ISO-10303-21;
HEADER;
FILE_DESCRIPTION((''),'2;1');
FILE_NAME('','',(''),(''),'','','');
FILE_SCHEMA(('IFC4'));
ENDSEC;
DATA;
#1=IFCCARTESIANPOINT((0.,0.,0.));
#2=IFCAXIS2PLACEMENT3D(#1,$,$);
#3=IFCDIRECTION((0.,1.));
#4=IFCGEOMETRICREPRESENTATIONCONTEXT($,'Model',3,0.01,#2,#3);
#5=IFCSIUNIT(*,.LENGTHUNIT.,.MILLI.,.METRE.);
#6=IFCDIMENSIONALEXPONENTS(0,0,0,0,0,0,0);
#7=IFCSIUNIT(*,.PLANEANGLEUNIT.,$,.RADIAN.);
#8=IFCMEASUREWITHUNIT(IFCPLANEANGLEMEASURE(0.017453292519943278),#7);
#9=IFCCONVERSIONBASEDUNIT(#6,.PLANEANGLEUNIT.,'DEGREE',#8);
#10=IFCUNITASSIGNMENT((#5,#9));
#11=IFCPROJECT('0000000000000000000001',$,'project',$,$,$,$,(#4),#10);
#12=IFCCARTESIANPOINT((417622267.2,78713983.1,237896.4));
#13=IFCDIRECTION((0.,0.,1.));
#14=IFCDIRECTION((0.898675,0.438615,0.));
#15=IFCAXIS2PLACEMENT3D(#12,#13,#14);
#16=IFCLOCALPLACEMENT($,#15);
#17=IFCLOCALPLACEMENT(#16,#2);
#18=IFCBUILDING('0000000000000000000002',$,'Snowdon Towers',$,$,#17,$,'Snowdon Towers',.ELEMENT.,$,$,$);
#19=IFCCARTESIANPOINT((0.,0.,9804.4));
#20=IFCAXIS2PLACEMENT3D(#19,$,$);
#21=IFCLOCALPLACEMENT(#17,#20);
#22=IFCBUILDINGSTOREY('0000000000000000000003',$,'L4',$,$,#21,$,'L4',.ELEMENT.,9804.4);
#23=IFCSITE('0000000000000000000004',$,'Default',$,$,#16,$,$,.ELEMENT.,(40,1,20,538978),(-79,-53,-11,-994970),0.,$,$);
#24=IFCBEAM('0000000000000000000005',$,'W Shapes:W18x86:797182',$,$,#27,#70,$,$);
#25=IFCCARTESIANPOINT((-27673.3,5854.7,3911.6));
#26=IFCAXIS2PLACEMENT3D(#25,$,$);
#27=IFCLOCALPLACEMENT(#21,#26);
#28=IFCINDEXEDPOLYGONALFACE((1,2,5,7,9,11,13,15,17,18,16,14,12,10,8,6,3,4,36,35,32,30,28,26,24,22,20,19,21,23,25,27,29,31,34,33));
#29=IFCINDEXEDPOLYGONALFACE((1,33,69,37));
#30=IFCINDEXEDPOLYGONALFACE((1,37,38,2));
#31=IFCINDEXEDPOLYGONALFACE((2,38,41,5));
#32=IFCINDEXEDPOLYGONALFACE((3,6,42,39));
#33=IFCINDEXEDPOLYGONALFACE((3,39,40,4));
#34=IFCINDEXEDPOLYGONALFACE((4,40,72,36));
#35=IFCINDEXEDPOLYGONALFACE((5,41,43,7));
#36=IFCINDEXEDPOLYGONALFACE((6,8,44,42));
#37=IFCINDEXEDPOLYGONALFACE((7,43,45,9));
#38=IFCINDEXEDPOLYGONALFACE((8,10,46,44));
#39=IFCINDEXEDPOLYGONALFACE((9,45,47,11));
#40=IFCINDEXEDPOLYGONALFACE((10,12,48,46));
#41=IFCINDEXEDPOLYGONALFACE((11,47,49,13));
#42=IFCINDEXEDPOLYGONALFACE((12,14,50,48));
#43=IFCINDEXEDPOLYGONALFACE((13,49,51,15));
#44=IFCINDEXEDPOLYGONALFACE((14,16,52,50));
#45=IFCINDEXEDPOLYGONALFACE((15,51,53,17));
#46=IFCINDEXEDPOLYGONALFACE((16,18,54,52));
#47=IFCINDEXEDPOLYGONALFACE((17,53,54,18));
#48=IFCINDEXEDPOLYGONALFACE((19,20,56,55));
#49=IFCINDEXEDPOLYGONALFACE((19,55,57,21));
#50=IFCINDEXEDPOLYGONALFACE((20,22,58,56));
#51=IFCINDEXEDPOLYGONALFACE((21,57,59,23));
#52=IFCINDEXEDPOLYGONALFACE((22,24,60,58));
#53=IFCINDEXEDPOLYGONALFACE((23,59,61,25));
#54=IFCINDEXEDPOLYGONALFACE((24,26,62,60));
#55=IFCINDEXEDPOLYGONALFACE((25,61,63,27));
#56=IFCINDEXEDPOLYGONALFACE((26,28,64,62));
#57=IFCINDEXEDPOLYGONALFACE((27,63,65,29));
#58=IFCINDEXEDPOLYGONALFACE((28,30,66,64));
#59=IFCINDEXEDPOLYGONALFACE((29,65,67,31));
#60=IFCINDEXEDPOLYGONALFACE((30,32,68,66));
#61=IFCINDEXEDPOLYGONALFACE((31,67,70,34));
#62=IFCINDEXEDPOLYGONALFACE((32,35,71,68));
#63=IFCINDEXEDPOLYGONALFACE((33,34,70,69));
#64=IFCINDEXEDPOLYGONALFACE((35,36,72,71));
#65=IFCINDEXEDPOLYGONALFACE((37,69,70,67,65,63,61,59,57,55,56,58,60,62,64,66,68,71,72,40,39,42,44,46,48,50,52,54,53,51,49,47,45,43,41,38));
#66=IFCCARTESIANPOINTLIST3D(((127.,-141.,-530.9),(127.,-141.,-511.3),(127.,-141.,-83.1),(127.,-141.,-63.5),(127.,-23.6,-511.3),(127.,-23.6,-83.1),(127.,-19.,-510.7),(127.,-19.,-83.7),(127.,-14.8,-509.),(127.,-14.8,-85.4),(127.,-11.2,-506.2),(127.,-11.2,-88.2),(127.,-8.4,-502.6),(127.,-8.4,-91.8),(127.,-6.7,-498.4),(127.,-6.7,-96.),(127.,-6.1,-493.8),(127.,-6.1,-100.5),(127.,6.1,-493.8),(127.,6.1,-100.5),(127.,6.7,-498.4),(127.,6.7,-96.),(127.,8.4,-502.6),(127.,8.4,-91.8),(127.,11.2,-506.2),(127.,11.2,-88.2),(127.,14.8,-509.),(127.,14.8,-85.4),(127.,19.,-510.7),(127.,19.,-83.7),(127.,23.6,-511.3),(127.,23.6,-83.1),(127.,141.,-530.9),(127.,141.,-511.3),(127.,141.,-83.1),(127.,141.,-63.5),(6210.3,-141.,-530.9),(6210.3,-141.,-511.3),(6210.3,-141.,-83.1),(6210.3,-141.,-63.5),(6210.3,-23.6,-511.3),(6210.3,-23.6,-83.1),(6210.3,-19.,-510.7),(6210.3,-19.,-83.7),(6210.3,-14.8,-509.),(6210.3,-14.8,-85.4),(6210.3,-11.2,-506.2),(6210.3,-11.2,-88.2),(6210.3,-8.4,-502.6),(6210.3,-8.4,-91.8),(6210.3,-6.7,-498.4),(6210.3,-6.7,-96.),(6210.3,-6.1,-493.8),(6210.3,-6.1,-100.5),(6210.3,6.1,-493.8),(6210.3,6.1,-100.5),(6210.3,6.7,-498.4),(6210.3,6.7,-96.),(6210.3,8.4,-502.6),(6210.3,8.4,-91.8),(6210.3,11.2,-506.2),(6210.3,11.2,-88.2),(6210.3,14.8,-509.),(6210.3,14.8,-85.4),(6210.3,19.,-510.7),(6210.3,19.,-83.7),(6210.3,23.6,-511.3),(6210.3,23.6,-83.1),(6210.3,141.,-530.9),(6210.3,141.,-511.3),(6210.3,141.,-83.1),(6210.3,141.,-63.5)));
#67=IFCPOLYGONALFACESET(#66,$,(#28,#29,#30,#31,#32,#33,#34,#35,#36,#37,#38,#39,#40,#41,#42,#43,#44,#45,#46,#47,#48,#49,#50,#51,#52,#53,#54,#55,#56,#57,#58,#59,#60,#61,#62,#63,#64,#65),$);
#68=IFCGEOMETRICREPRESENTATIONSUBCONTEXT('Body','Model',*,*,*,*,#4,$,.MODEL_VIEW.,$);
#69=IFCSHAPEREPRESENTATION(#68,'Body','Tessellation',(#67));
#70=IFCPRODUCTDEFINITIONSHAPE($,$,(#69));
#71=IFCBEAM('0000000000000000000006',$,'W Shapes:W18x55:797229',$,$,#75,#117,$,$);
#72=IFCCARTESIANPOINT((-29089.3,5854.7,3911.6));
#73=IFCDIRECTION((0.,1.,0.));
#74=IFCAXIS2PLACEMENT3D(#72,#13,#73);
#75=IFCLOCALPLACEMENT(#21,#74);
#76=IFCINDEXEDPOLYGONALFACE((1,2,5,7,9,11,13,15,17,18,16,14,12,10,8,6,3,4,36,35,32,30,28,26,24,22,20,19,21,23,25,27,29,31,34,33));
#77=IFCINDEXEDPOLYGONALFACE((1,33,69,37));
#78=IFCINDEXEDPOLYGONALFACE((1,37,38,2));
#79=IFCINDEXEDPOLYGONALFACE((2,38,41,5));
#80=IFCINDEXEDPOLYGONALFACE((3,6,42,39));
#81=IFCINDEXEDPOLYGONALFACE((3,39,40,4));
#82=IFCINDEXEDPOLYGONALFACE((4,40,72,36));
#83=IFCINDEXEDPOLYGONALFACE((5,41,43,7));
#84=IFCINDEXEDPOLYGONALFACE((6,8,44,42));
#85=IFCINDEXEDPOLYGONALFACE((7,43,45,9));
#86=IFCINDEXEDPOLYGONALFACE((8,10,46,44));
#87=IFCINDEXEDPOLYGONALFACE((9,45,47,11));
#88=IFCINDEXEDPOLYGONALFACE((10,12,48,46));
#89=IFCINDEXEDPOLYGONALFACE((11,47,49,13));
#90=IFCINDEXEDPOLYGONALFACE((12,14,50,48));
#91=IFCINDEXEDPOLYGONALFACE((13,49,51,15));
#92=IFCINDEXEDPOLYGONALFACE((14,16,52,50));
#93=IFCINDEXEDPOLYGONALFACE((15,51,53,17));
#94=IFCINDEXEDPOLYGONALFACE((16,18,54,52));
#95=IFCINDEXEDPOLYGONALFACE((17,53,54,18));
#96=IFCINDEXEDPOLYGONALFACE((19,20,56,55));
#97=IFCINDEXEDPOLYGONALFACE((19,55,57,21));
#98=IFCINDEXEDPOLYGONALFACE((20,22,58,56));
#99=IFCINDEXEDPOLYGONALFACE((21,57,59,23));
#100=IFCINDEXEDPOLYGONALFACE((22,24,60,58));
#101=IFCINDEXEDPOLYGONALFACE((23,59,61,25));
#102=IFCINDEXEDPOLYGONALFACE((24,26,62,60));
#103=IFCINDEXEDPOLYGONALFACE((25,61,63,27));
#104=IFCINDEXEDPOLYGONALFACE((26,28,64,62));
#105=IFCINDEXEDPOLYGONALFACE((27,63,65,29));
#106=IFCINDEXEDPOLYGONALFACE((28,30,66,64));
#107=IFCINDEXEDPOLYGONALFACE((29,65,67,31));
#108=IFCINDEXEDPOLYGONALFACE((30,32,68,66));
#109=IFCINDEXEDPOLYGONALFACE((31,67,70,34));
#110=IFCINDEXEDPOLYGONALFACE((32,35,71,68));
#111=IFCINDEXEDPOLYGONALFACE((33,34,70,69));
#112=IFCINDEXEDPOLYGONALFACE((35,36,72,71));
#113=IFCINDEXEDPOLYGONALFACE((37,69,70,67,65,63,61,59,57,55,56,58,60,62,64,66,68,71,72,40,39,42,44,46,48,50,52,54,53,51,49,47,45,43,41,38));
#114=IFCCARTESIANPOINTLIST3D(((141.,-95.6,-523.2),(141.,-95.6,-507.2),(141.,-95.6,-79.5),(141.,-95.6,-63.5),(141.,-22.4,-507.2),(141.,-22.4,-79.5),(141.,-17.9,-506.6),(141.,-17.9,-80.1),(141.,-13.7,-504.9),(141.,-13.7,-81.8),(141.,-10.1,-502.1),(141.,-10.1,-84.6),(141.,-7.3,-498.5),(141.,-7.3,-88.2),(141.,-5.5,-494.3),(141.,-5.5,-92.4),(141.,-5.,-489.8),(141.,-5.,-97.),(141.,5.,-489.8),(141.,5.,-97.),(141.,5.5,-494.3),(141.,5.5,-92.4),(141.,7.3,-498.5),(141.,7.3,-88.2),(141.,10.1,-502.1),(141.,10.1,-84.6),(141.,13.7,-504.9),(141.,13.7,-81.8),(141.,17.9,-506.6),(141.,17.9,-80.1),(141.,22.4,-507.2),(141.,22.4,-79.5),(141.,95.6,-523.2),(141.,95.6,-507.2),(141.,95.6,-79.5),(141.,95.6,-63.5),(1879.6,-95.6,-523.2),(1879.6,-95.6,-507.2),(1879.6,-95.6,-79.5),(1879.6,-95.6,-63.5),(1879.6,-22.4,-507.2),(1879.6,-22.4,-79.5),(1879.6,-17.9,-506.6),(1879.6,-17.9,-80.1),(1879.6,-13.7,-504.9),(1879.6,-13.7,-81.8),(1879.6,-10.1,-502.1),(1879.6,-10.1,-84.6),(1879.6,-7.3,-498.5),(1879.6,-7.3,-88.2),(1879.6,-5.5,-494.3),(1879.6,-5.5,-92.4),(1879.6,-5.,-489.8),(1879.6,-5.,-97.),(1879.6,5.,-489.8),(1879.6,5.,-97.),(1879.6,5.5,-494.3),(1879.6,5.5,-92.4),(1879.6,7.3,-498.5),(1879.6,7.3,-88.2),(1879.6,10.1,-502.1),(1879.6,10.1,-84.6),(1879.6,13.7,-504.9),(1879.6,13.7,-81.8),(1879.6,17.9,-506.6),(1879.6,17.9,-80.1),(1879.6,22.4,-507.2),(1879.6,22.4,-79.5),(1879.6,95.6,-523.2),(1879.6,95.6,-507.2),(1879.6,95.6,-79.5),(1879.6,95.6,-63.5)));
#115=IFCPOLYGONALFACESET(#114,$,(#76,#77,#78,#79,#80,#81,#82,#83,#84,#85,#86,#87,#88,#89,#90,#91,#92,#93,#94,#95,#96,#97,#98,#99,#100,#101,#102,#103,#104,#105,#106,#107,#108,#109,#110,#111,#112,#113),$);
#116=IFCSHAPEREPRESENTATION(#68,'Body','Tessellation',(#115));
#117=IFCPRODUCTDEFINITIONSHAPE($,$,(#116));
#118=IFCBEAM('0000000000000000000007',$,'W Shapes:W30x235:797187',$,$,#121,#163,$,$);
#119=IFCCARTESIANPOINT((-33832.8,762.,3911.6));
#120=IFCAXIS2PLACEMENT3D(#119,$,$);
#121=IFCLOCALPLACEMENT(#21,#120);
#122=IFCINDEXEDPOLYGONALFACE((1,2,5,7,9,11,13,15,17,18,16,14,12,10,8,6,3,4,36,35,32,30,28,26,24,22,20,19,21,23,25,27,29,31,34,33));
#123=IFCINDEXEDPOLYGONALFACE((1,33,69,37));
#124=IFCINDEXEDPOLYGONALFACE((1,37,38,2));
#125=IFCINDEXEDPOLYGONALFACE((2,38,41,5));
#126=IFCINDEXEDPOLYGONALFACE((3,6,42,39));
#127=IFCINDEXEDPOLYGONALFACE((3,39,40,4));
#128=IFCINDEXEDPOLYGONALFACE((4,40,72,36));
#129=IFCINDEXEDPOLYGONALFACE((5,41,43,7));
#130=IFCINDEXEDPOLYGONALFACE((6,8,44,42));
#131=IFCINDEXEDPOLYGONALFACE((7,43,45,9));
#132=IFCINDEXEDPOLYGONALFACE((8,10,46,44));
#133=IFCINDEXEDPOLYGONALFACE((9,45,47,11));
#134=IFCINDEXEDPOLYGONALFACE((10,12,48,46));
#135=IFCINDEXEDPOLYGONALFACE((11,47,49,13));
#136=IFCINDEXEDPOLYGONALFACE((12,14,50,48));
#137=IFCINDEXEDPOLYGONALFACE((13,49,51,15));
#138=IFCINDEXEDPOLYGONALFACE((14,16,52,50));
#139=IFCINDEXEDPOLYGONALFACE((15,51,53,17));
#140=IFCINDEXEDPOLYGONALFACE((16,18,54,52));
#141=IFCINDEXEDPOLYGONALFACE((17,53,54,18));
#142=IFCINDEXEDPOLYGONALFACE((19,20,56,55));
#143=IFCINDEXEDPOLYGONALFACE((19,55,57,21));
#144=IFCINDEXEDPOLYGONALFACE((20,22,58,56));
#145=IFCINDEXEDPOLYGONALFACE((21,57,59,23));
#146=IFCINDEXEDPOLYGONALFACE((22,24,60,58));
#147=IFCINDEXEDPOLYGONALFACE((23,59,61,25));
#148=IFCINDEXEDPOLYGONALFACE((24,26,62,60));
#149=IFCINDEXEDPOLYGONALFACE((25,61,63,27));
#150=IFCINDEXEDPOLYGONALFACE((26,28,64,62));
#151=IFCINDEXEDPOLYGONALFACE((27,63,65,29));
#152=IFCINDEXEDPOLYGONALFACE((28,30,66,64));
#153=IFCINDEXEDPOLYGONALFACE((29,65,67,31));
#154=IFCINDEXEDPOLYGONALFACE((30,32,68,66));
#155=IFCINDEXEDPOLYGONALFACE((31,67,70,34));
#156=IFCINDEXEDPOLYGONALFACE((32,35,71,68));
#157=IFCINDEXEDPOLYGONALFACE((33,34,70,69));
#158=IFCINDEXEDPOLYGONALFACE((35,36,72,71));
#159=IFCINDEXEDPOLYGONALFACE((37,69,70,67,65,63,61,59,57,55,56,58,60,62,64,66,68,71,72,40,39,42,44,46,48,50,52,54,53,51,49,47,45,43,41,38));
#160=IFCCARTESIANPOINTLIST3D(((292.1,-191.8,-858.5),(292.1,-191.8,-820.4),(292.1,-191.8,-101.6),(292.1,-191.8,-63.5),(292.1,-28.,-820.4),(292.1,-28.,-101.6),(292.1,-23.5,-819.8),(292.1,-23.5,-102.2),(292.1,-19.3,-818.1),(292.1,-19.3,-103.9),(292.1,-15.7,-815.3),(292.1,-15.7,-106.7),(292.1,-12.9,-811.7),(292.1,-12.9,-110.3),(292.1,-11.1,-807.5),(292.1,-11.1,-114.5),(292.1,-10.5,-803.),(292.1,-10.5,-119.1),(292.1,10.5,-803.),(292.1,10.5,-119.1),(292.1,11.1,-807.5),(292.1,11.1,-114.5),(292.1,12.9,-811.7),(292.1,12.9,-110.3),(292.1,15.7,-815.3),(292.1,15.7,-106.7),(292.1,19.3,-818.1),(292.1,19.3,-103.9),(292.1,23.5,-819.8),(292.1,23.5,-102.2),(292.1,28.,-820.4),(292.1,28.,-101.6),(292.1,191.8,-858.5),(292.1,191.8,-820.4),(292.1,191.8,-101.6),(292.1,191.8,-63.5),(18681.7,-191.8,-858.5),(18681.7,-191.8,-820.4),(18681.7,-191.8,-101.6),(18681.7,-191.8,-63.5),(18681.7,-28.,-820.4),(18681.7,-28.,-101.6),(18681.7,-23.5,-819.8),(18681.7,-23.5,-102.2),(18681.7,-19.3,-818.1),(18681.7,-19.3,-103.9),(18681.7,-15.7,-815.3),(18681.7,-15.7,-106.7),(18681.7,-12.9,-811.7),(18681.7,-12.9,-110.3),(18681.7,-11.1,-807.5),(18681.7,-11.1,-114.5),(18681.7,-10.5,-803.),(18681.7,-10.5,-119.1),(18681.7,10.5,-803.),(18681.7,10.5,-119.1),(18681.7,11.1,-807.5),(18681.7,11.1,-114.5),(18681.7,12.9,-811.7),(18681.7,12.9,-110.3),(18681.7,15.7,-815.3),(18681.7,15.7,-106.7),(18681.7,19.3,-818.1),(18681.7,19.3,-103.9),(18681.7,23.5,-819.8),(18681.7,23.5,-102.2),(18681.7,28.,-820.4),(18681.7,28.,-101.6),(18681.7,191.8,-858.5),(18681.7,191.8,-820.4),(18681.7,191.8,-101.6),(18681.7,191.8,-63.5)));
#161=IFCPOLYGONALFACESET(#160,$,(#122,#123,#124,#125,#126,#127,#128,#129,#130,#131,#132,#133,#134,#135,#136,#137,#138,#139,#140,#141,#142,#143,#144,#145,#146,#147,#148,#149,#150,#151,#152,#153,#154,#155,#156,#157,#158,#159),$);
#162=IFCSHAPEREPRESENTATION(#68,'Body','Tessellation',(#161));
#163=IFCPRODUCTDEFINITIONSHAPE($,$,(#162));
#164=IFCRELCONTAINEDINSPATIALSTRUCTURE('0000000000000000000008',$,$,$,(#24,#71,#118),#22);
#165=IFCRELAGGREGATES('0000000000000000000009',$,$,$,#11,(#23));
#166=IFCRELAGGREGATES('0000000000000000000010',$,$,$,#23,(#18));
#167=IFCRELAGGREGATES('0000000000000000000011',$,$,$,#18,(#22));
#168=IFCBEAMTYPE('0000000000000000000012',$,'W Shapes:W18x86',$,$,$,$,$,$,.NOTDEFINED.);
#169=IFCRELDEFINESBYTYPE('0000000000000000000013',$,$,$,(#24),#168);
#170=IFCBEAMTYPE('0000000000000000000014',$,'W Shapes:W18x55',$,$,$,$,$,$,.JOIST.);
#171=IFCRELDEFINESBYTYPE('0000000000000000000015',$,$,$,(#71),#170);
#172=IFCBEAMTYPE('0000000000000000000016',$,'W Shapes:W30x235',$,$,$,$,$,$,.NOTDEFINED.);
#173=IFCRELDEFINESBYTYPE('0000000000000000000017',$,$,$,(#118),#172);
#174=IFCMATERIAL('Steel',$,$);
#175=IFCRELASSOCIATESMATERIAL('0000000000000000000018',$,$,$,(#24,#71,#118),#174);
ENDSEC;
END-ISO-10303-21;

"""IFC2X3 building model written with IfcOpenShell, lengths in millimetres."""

from ifc_helpers import new_model, entity, si_unit, converted_unit, direction, frame, frame_2d, origin, place, context, subcontext, project, spatial, i_section, extrude, material, type_object, element, save


model = new_model("IFC2X3")

# Units and contexts
model_context = context("Model", 3, precision=0.01, world=origin(), true_north=direction((0.0, 1.0)))
body_context = subcontext(model_context, "Body", "Model", "MODEL_VIEW")
ifc_project = project(units=[si_unit("LENGTHUNIT", "METRE", prefix="MILLI"), converted_unit("PLANEANGLEUNIT", "DEGREE", entity("IfcPlaneAngleMeasure", 0.017453292519943278), si_unit("PLANEANGLEUNIT", "RADIAN"), dimensions=[0, 0, 0, 0, 0, 0, 0])], contexts=[model_context])

# Site, building, storey
site_placement = place(None, frame((417622267.2, 78713983.1, 237896.4), z_axis=(0.0, 0.0, 1.0), x_axis=(0.898675, 0.438615, 0.0)))
site = spatial("IfcSite", under=ifc_project, at=site_placement, Name="Default", CompositionType="ELEMENT", RefLatitude=(40, 1, 20, 538978), RefLongitude=(-79, -53, -11, -994970), RefElevation=0.0)
building_placement = place(site_placement, origin())
building = spatial("IfcBuilding", under=site, at=building_placement, Name="Snowdon Towers", LongName="Snowdon Towers", CompositionType="ELEMENT")
storey_placement = place(building_placement, frame((0.0, 0.0, 9804.4)))
storey = spatial("IfcBuildingStorey", under=building, at=storey_placement, Name="L4", LongName="L4", CompositionType="ELEMENT", Elevation=9804.4)

# Shared definitions
ifc_material_1 = material(Name="Steel")

# Beams
beam_type_1 = type_object("IfcBeamType", Name="W Shapes:W18x86", PredefinedType="NOTDEFINED")
beam_1_placement = place(storey_placement, frame((-27673.3, 5854.7, 3911.6)))
element("IfcBeam", 1, at=beam_1_placement, inside=storey, type_object=beam_type_1, material=ifc_material_1, Name="W Shapes:W18x86:797182", context=body_context, shape_type="SweptSolid", body=[
    extrude(i_section(OverallWidth=281.9, OverallDepth=467.4, WebThickness=12.2, FlangeThickness=19.6, FilletRadius=17.5, at=frame_2d((0.0, 0.0), x_axis=(0.0, 1.0))), frame((127.0, 0.0, -297.2), z_axis=(1.0, 0.0, 0.0), x_axis=(0.0, 0.0, -1.0)), (0.0, 0.0, 1.0), 6083.3),
])
beam_type_2 = type_object("IfcBeamType", Name="W Shapes:W18x55", PredefinedType="JOIST")
beam_2_placement = place(storey_placement, frame((-29089.3, 5854.7, 3911.6), z_axis=(0.0, 0.0, 1.0), x_axis=(0.0, 1.0, 0.0)))
element("IfcBeam", 2, at=beam_2_placement, inside=storey, type_object=beam_type_2, material=ifc_material_1, Name="W Shapes:W18x55:797229", context=body_context, shape_type="SweptSolid", body=[
    extrude(i_section(OverallWidth=191.3, OverallDepth=459.7, WebThickness=9.9, FlangeThickness=16.0, FilletRadius=17.5, at=frame_2d((0.0, 0.0), x_axis=(0.0, 1.0))), frame((141.0, 0.0, -293.4), z_axis=(1.0, 0.0, 0.0), x_axis=(0.0, 0.0, -1.0)), (0.0, 0.0, 1.0), 1738.6),
])
beam_type_3 = type_object("IfcBeamType", Name="W Shapes:W30x235", PredefinedType="NOTDEFINED")
beam_3_placement = place(storey_placement, frame((-33832.8, 762.0, 3911.6)))
element("IfcBeam", 3, at=beam_3_placement, inside=storey, type_object=beam_type_3, material=ifc_material_1, Name="W Shapes:W30x235:797187", context=body_context, shape_type="SweptSolid", body=[
    extrude(i_section(OverallWidth=383.5, OverallDepth=795.0, WebThickness=21.1, FlangeThickness=38.1, FilletRadius=17.5, at=frame_2d((0.0, 0.0), x_axis=(0.0, 1.0))), frame((292.1, 0.0, -461.0), z_axis=(1.0, 0.0, 0.0), x_axis=(0.0, 0.0, -1.0)), (0.0, 0.0, 1.0), 18389.6),
])

save(model, "model.ifc")
